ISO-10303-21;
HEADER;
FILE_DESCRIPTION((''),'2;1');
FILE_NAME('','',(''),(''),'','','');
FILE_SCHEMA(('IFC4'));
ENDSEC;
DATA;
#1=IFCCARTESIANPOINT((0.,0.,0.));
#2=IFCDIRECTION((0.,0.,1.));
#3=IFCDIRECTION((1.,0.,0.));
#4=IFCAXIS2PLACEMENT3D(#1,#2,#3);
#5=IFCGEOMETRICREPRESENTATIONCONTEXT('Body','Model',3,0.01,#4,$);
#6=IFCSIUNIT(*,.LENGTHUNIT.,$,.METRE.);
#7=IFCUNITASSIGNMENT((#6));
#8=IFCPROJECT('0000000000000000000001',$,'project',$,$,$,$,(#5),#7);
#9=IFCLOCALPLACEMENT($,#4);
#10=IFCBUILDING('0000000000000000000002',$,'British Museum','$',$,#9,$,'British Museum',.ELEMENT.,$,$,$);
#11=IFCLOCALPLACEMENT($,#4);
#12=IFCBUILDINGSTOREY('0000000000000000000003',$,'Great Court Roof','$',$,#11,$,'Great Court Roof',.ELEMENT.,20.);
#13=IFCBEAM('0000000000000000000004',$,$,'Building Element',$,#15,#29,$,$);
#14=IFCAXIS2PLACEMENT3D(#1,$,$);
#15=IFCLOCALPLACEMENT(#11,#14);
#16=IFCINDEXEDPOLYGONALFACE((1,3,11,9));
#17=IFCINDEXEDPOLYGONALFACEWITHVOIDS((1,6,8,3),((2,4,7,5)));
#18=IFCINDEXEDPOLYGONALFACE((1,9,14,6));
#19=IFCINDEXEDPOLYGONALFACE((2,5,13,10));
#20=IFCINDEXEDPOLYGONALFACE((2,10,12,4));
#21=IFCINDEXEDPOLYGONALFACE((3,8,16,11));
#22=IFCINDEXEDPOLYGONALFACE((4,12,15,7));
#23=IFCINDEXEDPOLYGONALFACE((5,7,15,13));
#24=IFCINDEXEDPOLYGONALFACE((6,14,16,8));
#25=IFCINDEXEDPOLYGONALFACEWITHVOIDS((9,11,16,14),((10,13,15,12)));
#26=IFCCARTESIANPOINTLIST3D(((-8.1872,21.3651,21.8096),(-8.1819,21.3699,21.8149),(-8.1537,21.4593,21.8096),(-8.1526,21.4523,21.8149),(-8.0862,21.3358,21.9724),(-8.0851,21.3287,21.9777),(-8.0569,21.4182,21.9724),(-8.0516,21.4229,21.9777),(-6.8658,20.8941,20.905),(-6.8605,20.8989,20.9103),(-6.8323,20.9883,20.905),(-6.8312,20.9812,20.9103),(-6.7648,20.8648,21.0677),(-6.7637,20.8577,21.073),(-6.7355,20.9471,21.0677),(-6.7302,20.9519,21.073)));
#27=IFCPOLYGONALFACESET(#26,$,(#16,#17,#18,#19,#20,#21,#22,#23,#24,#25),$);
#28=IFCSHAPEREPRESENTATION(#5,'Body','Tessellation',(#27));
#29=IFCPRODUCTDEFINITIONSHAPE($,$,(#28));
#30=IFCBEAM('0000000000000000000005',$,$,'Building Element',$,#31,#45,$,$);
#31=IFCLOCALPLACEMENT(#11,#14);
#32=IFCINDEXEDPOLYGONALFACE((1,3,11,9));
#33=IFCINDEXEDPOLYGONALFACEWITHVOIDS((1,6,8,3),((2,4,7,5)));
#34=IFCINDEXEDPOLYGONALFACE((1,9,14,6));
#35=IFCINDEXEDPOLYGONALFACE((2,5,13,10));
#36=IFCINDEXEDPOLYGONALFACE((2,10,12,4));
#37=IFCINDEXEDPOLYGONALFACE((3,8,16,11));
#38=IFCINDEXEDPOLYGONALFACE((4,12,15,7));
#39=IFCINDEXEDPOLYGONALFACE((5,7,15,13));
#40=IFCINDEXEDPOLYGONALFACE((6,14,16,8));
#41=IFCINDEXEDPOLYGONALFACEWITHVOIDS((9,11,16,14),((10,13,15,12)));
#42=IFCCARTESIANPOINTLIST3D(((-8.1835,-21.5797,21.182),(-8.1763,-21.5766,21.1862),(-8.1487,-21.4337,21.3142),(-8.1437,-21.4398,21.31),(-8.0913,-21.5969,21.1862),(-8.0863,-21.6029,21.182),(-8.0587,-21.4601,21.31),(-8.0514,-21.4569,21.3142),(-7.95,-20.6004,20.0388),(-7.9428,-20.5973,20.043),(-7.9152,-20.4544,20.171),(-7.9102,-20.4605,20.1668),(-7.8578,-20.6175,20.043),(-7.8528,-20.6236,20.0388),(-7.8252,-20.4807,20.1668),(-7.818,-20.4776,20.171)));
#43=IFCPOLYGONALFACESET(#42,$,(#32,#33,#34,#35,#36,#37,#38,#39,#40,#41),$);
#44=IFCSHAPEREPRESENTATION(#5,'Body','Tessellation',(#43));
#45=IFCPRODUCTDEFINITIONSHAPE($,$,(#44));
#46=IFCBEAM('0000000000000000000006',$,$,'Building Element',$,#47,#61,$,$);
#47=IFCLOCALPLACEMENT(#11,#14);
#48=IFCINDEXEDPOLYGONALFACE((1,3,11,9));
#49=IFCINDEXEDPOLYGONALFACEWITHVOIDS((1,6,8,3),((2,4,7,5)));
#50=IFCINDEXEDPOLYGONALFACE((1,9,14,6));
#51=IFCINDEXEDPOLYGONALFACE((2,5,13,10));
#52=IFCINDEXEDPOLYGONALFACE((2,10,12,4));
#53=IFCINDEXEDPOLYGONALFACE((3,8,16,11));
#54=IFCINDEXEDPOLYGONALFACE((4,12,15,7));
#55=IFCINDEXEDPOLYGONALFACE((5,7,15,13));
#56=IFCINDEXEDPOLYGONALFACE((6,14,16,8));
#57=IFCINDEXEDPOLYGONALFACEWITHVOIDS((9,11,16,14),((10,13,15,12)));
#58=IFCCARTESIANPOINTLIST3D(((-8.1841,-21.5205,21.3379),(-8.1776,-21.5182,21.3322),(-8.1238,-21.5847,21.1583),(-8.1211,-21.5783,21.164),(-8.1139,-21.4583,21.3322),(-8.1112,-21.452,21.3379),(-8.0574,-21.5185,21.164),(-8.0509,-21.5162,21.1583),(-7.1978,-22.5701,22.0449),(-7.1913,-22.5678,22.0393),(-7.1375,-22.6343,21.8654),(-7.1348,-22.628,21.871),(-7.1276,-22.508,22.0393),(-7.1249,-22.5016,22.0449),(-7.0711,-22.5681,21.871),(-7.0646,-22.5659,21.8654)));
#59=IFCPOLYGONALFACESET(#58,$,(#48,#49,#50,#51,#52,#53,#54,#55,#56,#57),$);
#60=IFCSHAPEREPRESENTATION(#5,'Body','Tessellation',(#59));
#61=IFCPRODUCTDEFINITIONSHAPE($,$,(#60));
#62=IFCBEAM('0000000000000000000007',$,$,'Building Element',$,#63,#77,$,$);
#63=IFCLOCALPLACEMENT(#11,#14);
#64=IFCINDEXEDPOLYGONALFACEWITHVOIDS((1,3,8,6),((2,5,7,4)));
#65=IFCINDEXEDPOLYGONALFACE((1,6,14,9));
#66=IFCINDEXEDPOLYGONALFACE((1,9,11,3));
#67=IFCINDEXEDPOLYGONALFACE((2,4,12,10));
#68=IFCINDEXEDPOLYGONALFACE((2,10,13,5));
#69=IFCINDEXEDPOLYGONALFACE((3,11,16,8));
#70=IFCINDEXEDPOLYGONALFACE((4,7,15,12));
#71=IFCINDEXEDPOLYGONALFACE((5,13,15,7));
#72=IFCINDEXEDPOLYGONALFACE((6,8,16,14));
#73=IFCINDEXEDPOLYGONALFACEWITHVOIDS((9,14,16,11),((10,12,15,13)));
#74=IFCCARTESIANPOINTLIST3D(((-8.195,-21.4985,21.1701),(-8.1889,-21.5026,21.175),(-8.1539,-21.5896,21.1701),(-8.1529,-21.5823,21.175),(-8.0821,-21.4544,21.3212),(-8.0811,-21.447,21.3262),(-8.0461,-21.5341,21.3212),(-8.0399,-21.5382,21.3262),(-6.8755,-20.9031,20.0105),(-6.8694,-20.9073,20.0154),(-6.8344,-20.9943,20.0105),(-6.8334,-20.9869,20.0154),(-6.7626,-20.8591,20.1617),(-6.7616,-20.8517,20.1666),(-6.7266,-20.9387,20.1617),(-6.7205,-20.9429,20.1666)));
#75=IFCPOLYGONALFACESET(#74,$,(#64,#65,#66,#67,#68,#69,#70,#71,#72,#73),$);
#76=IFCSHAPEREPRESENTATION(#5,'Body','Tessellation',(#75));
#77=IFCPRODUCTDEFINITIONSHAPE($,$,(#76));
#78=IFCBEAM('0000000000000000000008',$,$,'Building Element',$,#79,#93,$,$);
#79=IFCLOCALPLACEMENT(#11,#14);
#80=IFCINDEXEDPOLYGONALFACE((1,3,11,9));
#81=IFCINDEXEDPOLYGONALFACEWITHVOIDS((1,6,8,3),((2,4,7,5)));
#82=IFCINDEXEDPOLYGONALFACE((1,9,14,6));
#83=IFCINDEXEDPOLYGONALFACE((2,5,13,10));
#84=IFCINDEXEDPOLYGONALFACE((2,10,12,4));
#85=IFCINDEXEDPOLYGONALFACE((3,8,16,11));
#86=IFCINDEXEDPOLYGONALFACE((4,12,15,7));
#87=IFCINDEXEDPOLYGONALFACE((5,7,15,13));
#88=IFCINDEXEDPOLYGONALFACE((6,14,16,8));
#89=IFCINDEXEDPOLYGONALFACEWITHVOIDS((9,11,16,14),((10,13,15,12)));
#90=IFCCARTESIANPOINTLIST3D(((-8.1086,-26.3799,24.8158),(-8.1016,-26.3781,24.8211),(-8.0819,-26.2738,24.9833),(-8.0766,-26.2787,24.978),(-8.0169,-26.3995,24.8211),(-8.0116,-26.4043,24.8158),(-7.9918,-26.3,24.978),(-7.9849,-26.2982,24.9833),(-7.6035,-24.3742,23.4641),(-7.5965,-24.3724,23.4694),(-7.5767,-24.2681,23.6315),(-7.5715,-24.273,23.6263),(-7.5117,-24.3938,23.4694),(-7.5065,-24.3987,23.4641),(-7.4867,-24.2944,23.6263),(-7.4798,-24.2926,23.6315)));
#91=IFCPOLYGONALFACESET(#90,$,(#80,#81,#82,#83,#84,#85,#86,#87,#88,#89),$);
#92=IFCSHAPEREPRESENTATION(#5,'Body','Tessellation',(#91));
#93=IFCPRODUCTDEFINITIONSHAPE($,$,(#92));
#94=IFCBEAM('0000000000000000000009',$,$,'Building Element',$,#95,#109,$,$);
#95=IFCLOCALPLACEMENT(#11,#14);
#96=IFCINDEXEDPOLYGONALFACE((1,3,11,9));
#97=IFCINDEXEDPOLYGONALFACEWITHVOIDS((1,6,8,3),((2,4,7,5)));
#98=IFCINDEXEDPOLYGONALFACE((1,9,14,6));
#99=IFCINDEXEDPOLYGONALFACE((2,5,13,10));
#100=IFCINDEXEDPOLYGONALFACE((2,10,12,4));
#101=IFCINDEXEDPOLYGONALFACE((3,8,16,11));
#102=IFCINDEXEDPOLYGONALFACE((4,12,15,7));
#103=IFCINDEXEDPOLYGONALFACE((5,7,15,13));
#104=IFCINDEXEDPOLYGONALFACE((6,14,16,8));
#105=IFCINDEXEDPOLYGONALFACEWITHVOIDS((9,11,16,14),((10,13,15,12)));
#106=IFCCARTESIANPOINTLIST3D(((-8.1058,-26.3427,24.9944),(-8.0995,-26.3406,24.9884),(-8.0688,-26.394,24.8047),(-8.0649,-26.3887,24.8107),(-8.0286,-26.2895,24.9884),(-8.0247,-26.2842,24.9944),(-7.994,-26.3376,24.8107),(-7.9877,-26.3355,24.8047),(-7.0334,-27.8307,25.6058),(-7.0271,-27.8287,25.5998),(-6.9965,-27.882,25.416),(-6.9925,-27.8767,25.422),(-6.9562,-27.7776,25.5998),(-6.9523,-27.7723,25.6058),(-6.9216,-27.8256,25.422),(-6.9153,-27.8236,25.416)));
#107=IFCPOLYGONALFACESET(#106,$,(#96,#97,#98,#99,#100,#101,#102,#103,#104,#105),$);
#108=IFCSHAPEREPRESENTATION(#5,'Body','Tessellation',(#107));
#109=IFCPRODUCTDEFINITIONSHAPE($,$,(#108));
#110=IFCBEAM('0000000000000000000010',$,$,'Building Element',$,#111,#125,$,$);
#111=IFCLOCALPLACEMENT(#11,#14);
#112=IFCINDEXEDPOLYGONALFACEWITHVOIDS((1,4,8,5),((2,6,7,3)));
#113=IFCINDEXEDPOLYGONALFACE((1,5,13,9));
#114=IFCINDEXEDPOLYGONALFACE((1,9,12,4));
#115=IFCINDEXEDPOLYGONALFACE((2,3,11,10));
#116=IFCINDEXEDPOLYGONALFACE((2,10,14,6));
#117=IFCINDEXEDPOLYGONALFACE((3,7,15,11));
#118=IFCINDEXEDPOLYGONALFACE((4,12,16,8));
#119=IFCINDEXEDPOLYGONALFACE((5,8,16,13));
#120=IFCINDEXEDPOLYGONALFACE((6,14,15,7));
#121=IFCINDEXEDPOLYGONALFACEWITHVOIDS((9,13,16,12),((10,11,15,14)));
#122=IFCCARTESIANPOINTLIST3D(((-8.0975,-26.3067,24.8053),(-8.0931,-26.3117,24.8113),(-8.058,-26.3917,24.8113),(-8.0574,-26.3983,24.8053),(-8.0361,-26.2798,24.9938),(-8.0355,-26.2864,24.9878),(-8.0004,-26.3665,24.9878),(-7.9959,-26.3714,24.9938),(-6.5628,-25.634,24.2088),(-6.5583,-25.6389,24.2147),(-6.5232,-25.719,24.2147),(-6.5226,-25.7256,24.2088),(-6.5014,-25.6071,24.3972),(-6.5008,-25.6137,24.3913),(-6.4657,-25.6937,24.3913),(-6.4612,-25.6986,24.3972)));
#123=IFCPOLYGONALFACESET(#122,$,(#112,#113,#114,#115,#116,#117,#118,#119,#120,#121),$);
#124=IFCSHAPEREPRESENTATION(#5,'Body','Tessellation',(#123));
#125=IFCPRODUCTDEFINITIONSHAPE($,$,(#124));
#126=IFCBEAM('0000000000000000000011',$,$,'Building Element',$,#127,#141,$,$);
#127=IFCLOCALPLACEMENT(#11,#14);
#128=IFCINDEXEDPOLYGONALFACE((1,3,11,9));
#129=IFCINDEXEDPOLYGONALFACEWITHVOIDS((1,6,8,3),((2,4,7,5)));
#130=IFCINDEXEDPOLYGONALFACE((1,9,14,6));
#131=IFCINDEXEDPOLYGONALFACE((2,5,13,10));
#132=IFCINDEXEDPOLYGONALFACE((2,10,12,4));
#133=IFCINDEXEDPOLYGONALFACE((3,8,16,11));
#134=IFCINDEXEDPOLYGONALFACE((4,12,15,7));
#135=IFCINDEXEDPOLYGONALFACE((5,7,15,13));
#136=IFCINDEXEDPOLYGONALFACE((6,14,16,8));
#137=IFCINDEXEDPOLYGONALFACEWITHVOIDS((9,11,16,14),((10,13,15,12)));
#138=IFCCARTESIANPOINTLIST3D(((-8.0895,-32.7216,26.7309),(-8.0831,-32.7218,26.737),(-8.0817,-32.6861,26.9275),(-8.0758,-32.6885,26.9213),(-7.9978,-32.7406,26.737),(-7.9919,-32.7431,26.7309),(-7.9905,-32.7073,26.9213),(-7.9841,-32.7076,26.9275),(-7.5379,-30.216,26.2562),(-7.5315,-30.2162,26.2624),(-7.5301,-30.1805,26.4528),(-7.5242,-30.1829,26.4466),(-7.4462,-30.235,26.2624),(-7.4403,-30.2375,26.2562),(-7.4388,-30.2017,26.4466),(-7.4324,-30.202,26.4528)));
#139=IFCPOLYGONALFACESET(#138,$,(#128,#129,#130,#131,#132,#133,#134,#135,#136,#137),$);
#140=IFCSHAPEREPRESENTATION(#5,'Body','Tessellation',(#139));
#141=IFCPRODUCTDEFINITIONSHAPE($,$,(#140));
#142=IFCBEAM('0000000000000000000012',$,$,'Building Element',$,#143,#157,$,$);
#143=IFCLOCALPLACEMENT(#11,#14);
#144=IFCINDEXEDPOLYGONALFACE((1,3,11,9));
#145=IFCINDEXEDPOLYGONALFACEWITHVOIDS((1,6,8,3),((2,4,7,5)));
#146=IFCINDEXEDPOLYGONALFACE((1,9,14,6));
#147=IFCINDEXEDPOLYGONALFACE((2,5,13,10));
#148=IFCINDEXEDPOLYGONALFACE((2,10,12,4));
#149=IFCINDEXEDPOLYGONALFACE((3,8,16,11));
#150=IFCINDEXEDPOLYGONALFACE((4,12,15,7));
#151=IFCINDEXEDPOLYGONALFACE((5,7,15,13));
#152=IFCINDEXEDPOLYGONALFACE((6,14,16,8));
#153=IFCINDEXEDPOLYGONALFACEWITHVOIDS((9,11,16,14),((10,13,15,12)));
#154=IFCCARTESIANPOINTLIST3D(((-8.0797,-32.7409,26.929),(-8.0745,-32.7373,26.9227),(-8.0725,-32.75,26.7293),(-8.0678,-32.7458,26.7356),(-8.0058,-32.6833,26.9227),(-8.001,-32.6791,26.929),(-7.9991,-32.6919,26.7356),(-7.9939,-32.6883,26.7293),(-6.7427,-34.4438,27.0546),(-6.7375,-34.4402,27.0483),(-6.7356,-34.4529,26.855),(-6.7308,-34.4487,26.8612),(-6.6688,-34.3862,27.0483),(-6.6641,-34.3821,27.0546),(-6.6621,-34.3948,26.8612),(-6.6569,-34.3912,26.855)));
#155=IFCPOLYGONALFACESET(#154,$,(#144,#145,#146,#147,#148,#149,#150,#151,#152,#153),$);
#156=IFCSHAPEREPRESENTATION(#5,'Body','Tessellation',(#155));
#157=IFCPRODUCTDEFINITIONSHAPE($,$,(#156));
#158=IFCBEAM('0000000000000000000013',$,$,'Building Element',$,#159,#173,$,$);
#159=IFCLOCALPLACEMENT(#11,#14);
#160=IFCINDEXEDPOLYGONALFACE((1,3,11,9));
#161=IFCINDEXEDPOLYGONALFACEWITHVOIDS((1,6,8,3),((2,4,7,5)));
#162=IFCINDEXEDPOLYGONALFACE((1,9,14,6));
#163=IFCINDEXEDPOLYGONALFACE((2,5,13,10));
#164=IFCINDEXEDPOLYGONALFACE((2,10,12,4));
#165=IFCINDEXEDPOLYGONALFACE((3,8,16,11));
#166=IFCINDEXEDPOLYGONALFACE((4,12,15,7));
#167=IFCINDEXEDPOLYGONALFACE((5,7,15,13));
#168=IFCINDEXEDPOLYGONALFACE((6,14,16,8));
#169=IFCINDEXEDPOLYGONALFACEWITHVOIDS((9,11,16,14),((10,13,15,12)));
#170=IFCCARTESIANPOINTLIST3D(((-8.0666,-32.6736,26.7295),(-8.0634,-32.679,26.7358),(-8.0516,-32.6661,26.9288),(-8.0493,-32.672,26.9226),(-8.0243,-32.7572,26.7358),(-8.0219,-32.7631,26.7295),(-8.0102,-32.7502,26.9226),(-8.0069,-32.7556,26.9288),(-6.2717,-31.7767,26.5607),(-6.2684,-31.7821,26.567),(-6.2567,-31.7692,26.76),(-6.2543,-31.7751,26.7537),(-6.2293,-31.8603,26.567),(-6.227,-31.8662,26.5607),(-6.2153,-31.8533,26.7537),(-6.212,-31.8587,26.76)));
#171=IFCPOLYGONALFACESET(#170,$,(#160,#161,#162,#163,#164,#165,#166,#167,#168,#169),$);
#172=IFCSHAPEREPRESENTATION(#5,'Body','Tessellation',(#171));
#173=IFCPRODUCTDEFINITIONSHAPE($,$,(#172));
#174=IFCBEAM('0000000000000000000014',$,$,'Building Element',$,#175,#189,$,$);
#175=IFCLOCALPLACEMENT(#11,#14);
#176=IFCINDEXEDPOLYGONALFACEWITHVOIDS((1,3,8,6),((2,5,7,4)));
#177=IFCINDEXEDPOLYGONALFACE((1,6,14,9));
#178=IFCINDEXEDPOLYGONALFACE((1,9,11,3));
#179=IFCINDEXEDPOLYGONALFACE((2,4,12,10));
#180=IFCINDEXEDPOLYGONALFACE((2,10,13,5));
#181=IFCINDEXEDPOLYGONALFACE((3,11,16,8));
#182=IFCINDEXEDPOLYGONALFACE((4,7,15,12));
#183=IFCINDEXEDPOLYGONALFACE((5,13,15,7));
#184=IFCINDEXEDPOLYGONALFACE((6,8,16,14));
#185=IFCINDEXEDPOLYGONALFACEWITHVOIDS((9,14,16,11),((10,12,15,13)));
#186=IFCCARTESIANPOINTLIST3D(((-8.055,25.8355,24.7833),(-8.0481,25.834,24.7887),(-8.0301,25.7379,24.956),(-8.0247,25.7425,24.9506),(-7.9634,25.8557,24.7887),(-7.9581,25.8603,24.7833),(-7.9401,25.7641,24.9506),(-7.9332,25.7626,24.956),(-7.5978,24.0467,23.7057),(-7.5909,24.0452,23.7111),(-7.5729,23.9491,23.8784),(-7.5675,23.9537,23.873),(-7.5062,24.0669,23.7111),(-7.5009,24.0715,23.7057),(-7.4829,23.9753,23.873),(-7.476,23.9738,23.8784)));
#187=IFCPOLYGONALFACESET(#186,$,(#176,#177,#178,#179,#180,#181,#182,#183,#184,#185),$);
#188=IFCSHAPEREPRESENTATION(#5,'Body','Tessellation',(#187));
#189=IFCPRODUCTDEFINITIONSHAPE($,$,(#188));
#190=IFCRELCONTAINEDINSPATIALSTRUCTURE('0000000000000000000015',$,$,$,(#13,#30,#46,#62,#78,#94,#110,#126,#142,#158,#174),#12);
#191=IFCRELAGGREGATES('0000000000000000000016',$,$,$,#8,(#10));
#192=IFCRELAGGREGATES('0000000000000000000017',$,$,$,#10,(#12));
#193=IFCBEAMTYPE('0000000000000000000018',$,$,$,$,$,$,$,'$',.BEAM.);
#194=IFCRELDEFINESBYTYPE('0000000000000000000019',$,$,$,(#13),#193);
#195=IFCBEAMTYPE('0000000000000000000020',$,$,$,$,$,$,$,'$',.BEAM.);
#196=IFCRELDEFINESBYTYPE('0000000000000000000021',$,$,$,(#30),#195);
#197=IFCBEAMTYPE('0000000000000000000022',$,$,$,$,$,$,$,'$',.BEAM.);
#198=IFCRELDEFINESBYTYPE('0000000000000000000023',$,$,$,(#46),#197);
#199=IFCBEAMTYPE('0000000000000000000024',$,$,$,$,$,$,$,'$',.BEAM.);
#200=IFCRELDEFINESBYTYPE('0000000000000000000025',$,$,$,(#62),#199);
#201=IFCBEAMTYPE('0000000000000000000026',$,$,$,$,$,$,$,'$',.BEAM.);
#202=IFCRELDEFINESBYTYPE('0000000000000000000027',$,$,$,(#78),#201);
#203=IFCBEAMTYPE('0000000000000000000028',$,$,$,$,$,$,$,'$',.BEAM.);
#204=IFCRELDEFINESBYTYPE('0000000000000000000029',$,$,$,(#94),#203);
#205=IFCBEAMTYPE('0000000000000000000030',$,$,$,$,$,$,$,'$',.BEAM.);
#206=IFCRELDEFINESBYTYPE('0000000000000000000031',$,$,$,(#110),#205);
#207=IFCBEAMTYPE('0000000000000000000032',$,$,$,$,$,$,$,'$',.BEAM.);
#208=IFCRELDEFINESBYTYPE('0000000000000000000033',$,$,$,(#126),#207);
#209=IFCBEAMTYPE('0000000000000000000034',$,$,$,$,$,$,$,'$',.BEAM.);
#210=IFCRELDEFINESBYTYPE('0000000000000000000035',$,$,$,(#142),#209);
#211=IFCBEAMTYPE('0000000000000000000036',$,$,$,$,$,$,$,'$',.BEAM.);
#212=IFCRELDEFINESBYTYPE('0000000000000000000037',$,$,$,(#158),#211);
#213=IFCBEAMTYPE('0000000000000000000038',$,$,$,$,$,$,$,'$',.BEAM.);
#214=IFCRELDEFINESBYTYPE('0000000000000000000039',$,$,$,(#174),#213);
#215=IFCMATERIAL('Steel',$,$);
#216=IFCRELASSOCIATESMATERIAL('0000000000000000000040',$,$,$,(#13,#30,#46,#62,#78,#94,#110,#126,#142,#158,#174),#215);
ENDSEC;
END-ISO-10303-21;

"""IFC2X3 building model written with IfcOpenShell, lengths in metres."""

from ifc_helpers import new_model, si_unit, frame, origin_with_axes, origin_2d, place, context, project, spatial, hollow_rectangle, extrude, material, type_object, element, save


model = new_model("IFC2X3")

# Units and contexts
model_context = context("Model", 3, precision=0.01, world=origin_with_axes(), identifier="Body")
ifc_project = project(units=[si_unit("LENGTHUNIT", "METRE")], contexts=[model_context])

# Building, storey
building_placement = place(None, origin_with_axes())
building = spatial("IfcBuilding", under=ifc_project, at=building_placement, Name="British Museum", Description="$", LongName="British Museum", CompositionType="ELEMENT")
storey_placement = place(None, origin_with_axes())
storey = spatial("IfcBuildingStorey", under=building, at=storey_placement, Name="Great Court Roof", Description="$", LongName="Great Court Roof", CompositionType="ELEMENT", Elevation=20.0)

# Beams
ifc_material = material(Name="Steel")
beam_type_1 = type_object("IfcBeamType", ElementType="$", PredefinedType="BEAM")
beam_1_placement = place(None, origin_with_axes())
element("IfcBeam", 1, at=beam_1_placement, inside=storey, type_object=beam_type_1, material=ifc_material, Description="Building Element", context=model_context, shape_type="SweptSolid", body=[
    extrude(hollow_rectangle(XDim=0.1, YDim=0.2, WallThickness=0.0063, InnerFilletRadius=-0.0063, OuterFilletRadius=0.0, at=origin_2d()), frame((-8.1194, 21.394, 21.8936), z_axis=(0.791624, -0.282191, -0.54194), x_axis=(0.335775, 0.941942, 0.0)), (0.0, 0.0, 1.0), 1.6692),
])
beam_type_2 = type_object("IfcBeamType", ElementType="$", PredefinedType="BEAM")
beam_2_placement = place(None, origin_with_axes())
element("IfcBeam", 2, at=beam_2_placement, inside=storey, type_object=beam_type_2, material=ifc_material, Description="Building Element", context=model_context, shape_type="SweptSolid", body=[
    extrude(hollow_rectangle(XDim=0.1, YDim=0.2, WallThickness=0.0063, InnerFilletRadius=-0.0063, OuterFilletRadius=0.0, at=origin_2d()), frame((-8.1175, -21.5183, 21.2481), z_axis=(0.153274, 0.642886, -0.75047), x_axis=(-0.972736, 0.231916, 0.0)), (0.0, 0.0, 1.0), 1.5233),
])
beam_type_3 = type_object("IfcBeamType", ElementType="$", PredefinedType="BEAM")
beam_3_placement = place(None, origin_with_axes())
element("IfcBeam", 3, at=beam_3_placement, inside=storey, type_object=beam_type_3, material=ifc_material, Description="Building Element", context=model_context, shape_type="SweptSolid", body=[
    extrude(hollow_rectangle(XDim=0.1, YDim=0.2, WallThickness=0.0063, InnerFilletRadius=-0.0063, OuterFilletRadius=0.0, at=origin_2d()), frame((-8.1175, -21.5183, 21.2481), z_axis=(0.614701, -0.654188, 0.440659), x_axis=(0.728759, 0.68477, 0.0)), (0.0, 0.0, 1.0), 1.6045),
])
beam_type_4 = type_object("IfcBeamType", ElementType="$", PredefinedType="BEAM")
beam_4_placement = place(None, origin_with_axes())
element("IfcBeam", 4, at=beam_4_placement, inside=storey, type_object=beam_type_4, material=ifc_material, Description="Building Element", context=model_context, shape_type="SweptSolid", body=[
    extrude(hollow_rectangle(XDim=0.1, YDim=0.2, WallThickness=0.0063, InnerFilletRadius=-0.0063, OuterFilletRadius=0.0, at=origin_2d()), frame((-8.1175, -21.5183, 21.2481), z_axis=(0.711419, 0.320982, -0.625182), x_axis=(-0.411264, 0.911516, 0.0)), (0.0, 0.0, 1.0), 1.8547),
])
beam_type_5 = type_object("IfcBeamType", ElementType="$", PredefinedType="BEAM")
beam_5_placement = place(None, origin_with_axes())
element("IfcBeam", 5, at=beam_5_placement, inside=storey, type_object=beam_type_5, material=ifc_material, Description="Building Element", context=model_context, shape_type="SweptSolid", body=[
    extrude(hollow_rectangle(XDim=0.1, YDim=0.2, WallThickness=0.0063, InnerFilletRadius=-0.0063, OuterFilletRadius=0.0, at=origin_2d()), frame((-8.0467, -26.3391, 24.8996), z_axis=(0.204437, 0.811737, -0.547073), x_axis=(-0.969719, 0.244225, 0.0)), (0.0, 0.0, 1.0), 2.4708),
])
beam_type_6 = type_object("IfcBeamType", ElementType="$", PredefinedType="BEAM")
beam_6_placement = place(None, origin_with_axes())
element("IfcBeam", 6, at=beam_6_placement, inside=storey, type_object=beam_type_6, material=ifc_material, Description="Building Element", context=model_context, shape_type="SweptSolid", body=[
    extrude(hollow_rectangle(XDim=0.1, YDim=0.2, WallThickness=0.0063, InnerFilletRadius=-0.0063, OuterFilletRadius=0.0, at=origin_2d()), frame((-8.0467, -26.3391, 24.8996), z_axis=(0.554648, -0.769666, 0.316196), x_axis=(0.81129, 0.584643, 0.0)), (0.0, 0.0, 1.0), 1.9334),
])
beam_type_7 = type_object("IfcBeamType", ElementType="$", PredefinedType="BEAM")
beam_7_placement = place(None, origin_with_axes())
element("IfcBeam", 7, at=beam_7_placement, inside=storey, type_object=beam_type_7, material=ifc_material, Description="Building Element", context=model_context, shape_type="SweptSolid", body=[
    extrude(hollow_rectangle(XDim=0.1, YDim=0.2, WallThickness=0.0063, InnerFilletRadius=-0.0063, OuterFilletRadius=0.0, at=origin_2d()), frame((-8.0467, -26.3391, 24.8996), z_axis=(0.862825, 0.378226, -0.335377), x_axis=(-0.401477, 0.915869, 0.0)), (0.0, 0.0, 1.0), 1.7787),
])
beam_type_8 = type_object("IfcBeamType", ElementType="$", PredefinedType="BEAM")
beam_8_placement = place(None, origin_with_axes())
element("IfcBeam", 8, at=beam_8_placement, inside=storey, type_object=beam_type_8, material=ifc_material, Description="Building Element", context=model_context, shape_type="SweptSolid", body=[
    extrude(hollow_rectangle(XDim=0.1, YDim=0.2, WallThickness=0.0063, InnerFilletRadius=-0.0063, OuterFilletRadius=0.0, at=origin_2d()), frame((-8.0368, -32.7146, 26.8292), z_axis=(0.211419, 0.960313, -0.181935), x_axis=(-0.976612, 0.215007, 0.0)), (0.0, 0.0, 1.0), 2.6091),
])
beam_type_9 = type_object("IfcBeamType", ElementType="$", PredefinedType="BEAM")
beam_9_placement = place(None, origin_with_axes())
element("IfcBeam", 9, at=beam_9_placement, inside=storey, type_object=beam_type_9, material=ifc_material, Description="Building Element", context=model_context, shape_type="SweptSolid", body=[
    extrude(hollow_rectangle(XDim=0.1, YDim=0.2, WallThickness=0.0063, InnerFilletRadius=-0.0063, OuterFilletRadius=0.0, at=origin_2d()), frame((-8.0368, -32.7146, 26.8292), z_axis=(0.616492, -0.785228, 0.057919), x_axis=(0.786548, 0.617529, 0.0)), (0.0, 0.0, 1.0), 2.1687),
])
beam_type_10 = type_object("IfcBeamType", ElementType="$", PredefinedType="BEAM")
beam_10_placement = place(None, origin_with_axes())
element("IfcBeam", 10, at=beam_10_placement, inside=storey, type_object=beam_type_10, material=ifc_material, Description="Building Element", context=model_context, shape_type="SweptSolid", body=[
    extrude(hollow_rectangle(XDim=0.1, YDim=0.2, WallThickness=0.0063, InnerFilletRadius=-0.0063, OuterFilletRadius=0.0, at=origin_2d()), frame((-8.0368, -32.7146, 26.8292), z_axis=(0.8914, 0.445394, -0.083847), x_axis=(-0.446968, 0.89455, 0.0)), (0.0, 0.0, 1.0), 2.0136),
])
beam_type_11 = type_object("IfcBeamType", ElementType="$", PredefinedType="BEAM")
beam_11_placement = place(None, origin_with_axes())
element("IfcBeam", 11, at=beam_11_placement, inside=storey, type_object=beam_type_11, material=ifc_material, Description="Building Element", context=model_context, shape_type="SweptSolid", body=[
    extrude(hollow_rectangle(XDim=0.1, YDim=0.2, WallThickness=0.0063, InnerFilletRadius=-0.0063, OuterFilletRadius=0.0, at=origin_2d()), frame((-7.9941, 25.7991, 24.8696), z_axis=(0.213868, -0.836764, -0.504069), x_axis=(0.968855, 0.24763, 0.0)), (0.0, 0.0, 1.0), 2.1378),
])

save(model, "model.ifc")
